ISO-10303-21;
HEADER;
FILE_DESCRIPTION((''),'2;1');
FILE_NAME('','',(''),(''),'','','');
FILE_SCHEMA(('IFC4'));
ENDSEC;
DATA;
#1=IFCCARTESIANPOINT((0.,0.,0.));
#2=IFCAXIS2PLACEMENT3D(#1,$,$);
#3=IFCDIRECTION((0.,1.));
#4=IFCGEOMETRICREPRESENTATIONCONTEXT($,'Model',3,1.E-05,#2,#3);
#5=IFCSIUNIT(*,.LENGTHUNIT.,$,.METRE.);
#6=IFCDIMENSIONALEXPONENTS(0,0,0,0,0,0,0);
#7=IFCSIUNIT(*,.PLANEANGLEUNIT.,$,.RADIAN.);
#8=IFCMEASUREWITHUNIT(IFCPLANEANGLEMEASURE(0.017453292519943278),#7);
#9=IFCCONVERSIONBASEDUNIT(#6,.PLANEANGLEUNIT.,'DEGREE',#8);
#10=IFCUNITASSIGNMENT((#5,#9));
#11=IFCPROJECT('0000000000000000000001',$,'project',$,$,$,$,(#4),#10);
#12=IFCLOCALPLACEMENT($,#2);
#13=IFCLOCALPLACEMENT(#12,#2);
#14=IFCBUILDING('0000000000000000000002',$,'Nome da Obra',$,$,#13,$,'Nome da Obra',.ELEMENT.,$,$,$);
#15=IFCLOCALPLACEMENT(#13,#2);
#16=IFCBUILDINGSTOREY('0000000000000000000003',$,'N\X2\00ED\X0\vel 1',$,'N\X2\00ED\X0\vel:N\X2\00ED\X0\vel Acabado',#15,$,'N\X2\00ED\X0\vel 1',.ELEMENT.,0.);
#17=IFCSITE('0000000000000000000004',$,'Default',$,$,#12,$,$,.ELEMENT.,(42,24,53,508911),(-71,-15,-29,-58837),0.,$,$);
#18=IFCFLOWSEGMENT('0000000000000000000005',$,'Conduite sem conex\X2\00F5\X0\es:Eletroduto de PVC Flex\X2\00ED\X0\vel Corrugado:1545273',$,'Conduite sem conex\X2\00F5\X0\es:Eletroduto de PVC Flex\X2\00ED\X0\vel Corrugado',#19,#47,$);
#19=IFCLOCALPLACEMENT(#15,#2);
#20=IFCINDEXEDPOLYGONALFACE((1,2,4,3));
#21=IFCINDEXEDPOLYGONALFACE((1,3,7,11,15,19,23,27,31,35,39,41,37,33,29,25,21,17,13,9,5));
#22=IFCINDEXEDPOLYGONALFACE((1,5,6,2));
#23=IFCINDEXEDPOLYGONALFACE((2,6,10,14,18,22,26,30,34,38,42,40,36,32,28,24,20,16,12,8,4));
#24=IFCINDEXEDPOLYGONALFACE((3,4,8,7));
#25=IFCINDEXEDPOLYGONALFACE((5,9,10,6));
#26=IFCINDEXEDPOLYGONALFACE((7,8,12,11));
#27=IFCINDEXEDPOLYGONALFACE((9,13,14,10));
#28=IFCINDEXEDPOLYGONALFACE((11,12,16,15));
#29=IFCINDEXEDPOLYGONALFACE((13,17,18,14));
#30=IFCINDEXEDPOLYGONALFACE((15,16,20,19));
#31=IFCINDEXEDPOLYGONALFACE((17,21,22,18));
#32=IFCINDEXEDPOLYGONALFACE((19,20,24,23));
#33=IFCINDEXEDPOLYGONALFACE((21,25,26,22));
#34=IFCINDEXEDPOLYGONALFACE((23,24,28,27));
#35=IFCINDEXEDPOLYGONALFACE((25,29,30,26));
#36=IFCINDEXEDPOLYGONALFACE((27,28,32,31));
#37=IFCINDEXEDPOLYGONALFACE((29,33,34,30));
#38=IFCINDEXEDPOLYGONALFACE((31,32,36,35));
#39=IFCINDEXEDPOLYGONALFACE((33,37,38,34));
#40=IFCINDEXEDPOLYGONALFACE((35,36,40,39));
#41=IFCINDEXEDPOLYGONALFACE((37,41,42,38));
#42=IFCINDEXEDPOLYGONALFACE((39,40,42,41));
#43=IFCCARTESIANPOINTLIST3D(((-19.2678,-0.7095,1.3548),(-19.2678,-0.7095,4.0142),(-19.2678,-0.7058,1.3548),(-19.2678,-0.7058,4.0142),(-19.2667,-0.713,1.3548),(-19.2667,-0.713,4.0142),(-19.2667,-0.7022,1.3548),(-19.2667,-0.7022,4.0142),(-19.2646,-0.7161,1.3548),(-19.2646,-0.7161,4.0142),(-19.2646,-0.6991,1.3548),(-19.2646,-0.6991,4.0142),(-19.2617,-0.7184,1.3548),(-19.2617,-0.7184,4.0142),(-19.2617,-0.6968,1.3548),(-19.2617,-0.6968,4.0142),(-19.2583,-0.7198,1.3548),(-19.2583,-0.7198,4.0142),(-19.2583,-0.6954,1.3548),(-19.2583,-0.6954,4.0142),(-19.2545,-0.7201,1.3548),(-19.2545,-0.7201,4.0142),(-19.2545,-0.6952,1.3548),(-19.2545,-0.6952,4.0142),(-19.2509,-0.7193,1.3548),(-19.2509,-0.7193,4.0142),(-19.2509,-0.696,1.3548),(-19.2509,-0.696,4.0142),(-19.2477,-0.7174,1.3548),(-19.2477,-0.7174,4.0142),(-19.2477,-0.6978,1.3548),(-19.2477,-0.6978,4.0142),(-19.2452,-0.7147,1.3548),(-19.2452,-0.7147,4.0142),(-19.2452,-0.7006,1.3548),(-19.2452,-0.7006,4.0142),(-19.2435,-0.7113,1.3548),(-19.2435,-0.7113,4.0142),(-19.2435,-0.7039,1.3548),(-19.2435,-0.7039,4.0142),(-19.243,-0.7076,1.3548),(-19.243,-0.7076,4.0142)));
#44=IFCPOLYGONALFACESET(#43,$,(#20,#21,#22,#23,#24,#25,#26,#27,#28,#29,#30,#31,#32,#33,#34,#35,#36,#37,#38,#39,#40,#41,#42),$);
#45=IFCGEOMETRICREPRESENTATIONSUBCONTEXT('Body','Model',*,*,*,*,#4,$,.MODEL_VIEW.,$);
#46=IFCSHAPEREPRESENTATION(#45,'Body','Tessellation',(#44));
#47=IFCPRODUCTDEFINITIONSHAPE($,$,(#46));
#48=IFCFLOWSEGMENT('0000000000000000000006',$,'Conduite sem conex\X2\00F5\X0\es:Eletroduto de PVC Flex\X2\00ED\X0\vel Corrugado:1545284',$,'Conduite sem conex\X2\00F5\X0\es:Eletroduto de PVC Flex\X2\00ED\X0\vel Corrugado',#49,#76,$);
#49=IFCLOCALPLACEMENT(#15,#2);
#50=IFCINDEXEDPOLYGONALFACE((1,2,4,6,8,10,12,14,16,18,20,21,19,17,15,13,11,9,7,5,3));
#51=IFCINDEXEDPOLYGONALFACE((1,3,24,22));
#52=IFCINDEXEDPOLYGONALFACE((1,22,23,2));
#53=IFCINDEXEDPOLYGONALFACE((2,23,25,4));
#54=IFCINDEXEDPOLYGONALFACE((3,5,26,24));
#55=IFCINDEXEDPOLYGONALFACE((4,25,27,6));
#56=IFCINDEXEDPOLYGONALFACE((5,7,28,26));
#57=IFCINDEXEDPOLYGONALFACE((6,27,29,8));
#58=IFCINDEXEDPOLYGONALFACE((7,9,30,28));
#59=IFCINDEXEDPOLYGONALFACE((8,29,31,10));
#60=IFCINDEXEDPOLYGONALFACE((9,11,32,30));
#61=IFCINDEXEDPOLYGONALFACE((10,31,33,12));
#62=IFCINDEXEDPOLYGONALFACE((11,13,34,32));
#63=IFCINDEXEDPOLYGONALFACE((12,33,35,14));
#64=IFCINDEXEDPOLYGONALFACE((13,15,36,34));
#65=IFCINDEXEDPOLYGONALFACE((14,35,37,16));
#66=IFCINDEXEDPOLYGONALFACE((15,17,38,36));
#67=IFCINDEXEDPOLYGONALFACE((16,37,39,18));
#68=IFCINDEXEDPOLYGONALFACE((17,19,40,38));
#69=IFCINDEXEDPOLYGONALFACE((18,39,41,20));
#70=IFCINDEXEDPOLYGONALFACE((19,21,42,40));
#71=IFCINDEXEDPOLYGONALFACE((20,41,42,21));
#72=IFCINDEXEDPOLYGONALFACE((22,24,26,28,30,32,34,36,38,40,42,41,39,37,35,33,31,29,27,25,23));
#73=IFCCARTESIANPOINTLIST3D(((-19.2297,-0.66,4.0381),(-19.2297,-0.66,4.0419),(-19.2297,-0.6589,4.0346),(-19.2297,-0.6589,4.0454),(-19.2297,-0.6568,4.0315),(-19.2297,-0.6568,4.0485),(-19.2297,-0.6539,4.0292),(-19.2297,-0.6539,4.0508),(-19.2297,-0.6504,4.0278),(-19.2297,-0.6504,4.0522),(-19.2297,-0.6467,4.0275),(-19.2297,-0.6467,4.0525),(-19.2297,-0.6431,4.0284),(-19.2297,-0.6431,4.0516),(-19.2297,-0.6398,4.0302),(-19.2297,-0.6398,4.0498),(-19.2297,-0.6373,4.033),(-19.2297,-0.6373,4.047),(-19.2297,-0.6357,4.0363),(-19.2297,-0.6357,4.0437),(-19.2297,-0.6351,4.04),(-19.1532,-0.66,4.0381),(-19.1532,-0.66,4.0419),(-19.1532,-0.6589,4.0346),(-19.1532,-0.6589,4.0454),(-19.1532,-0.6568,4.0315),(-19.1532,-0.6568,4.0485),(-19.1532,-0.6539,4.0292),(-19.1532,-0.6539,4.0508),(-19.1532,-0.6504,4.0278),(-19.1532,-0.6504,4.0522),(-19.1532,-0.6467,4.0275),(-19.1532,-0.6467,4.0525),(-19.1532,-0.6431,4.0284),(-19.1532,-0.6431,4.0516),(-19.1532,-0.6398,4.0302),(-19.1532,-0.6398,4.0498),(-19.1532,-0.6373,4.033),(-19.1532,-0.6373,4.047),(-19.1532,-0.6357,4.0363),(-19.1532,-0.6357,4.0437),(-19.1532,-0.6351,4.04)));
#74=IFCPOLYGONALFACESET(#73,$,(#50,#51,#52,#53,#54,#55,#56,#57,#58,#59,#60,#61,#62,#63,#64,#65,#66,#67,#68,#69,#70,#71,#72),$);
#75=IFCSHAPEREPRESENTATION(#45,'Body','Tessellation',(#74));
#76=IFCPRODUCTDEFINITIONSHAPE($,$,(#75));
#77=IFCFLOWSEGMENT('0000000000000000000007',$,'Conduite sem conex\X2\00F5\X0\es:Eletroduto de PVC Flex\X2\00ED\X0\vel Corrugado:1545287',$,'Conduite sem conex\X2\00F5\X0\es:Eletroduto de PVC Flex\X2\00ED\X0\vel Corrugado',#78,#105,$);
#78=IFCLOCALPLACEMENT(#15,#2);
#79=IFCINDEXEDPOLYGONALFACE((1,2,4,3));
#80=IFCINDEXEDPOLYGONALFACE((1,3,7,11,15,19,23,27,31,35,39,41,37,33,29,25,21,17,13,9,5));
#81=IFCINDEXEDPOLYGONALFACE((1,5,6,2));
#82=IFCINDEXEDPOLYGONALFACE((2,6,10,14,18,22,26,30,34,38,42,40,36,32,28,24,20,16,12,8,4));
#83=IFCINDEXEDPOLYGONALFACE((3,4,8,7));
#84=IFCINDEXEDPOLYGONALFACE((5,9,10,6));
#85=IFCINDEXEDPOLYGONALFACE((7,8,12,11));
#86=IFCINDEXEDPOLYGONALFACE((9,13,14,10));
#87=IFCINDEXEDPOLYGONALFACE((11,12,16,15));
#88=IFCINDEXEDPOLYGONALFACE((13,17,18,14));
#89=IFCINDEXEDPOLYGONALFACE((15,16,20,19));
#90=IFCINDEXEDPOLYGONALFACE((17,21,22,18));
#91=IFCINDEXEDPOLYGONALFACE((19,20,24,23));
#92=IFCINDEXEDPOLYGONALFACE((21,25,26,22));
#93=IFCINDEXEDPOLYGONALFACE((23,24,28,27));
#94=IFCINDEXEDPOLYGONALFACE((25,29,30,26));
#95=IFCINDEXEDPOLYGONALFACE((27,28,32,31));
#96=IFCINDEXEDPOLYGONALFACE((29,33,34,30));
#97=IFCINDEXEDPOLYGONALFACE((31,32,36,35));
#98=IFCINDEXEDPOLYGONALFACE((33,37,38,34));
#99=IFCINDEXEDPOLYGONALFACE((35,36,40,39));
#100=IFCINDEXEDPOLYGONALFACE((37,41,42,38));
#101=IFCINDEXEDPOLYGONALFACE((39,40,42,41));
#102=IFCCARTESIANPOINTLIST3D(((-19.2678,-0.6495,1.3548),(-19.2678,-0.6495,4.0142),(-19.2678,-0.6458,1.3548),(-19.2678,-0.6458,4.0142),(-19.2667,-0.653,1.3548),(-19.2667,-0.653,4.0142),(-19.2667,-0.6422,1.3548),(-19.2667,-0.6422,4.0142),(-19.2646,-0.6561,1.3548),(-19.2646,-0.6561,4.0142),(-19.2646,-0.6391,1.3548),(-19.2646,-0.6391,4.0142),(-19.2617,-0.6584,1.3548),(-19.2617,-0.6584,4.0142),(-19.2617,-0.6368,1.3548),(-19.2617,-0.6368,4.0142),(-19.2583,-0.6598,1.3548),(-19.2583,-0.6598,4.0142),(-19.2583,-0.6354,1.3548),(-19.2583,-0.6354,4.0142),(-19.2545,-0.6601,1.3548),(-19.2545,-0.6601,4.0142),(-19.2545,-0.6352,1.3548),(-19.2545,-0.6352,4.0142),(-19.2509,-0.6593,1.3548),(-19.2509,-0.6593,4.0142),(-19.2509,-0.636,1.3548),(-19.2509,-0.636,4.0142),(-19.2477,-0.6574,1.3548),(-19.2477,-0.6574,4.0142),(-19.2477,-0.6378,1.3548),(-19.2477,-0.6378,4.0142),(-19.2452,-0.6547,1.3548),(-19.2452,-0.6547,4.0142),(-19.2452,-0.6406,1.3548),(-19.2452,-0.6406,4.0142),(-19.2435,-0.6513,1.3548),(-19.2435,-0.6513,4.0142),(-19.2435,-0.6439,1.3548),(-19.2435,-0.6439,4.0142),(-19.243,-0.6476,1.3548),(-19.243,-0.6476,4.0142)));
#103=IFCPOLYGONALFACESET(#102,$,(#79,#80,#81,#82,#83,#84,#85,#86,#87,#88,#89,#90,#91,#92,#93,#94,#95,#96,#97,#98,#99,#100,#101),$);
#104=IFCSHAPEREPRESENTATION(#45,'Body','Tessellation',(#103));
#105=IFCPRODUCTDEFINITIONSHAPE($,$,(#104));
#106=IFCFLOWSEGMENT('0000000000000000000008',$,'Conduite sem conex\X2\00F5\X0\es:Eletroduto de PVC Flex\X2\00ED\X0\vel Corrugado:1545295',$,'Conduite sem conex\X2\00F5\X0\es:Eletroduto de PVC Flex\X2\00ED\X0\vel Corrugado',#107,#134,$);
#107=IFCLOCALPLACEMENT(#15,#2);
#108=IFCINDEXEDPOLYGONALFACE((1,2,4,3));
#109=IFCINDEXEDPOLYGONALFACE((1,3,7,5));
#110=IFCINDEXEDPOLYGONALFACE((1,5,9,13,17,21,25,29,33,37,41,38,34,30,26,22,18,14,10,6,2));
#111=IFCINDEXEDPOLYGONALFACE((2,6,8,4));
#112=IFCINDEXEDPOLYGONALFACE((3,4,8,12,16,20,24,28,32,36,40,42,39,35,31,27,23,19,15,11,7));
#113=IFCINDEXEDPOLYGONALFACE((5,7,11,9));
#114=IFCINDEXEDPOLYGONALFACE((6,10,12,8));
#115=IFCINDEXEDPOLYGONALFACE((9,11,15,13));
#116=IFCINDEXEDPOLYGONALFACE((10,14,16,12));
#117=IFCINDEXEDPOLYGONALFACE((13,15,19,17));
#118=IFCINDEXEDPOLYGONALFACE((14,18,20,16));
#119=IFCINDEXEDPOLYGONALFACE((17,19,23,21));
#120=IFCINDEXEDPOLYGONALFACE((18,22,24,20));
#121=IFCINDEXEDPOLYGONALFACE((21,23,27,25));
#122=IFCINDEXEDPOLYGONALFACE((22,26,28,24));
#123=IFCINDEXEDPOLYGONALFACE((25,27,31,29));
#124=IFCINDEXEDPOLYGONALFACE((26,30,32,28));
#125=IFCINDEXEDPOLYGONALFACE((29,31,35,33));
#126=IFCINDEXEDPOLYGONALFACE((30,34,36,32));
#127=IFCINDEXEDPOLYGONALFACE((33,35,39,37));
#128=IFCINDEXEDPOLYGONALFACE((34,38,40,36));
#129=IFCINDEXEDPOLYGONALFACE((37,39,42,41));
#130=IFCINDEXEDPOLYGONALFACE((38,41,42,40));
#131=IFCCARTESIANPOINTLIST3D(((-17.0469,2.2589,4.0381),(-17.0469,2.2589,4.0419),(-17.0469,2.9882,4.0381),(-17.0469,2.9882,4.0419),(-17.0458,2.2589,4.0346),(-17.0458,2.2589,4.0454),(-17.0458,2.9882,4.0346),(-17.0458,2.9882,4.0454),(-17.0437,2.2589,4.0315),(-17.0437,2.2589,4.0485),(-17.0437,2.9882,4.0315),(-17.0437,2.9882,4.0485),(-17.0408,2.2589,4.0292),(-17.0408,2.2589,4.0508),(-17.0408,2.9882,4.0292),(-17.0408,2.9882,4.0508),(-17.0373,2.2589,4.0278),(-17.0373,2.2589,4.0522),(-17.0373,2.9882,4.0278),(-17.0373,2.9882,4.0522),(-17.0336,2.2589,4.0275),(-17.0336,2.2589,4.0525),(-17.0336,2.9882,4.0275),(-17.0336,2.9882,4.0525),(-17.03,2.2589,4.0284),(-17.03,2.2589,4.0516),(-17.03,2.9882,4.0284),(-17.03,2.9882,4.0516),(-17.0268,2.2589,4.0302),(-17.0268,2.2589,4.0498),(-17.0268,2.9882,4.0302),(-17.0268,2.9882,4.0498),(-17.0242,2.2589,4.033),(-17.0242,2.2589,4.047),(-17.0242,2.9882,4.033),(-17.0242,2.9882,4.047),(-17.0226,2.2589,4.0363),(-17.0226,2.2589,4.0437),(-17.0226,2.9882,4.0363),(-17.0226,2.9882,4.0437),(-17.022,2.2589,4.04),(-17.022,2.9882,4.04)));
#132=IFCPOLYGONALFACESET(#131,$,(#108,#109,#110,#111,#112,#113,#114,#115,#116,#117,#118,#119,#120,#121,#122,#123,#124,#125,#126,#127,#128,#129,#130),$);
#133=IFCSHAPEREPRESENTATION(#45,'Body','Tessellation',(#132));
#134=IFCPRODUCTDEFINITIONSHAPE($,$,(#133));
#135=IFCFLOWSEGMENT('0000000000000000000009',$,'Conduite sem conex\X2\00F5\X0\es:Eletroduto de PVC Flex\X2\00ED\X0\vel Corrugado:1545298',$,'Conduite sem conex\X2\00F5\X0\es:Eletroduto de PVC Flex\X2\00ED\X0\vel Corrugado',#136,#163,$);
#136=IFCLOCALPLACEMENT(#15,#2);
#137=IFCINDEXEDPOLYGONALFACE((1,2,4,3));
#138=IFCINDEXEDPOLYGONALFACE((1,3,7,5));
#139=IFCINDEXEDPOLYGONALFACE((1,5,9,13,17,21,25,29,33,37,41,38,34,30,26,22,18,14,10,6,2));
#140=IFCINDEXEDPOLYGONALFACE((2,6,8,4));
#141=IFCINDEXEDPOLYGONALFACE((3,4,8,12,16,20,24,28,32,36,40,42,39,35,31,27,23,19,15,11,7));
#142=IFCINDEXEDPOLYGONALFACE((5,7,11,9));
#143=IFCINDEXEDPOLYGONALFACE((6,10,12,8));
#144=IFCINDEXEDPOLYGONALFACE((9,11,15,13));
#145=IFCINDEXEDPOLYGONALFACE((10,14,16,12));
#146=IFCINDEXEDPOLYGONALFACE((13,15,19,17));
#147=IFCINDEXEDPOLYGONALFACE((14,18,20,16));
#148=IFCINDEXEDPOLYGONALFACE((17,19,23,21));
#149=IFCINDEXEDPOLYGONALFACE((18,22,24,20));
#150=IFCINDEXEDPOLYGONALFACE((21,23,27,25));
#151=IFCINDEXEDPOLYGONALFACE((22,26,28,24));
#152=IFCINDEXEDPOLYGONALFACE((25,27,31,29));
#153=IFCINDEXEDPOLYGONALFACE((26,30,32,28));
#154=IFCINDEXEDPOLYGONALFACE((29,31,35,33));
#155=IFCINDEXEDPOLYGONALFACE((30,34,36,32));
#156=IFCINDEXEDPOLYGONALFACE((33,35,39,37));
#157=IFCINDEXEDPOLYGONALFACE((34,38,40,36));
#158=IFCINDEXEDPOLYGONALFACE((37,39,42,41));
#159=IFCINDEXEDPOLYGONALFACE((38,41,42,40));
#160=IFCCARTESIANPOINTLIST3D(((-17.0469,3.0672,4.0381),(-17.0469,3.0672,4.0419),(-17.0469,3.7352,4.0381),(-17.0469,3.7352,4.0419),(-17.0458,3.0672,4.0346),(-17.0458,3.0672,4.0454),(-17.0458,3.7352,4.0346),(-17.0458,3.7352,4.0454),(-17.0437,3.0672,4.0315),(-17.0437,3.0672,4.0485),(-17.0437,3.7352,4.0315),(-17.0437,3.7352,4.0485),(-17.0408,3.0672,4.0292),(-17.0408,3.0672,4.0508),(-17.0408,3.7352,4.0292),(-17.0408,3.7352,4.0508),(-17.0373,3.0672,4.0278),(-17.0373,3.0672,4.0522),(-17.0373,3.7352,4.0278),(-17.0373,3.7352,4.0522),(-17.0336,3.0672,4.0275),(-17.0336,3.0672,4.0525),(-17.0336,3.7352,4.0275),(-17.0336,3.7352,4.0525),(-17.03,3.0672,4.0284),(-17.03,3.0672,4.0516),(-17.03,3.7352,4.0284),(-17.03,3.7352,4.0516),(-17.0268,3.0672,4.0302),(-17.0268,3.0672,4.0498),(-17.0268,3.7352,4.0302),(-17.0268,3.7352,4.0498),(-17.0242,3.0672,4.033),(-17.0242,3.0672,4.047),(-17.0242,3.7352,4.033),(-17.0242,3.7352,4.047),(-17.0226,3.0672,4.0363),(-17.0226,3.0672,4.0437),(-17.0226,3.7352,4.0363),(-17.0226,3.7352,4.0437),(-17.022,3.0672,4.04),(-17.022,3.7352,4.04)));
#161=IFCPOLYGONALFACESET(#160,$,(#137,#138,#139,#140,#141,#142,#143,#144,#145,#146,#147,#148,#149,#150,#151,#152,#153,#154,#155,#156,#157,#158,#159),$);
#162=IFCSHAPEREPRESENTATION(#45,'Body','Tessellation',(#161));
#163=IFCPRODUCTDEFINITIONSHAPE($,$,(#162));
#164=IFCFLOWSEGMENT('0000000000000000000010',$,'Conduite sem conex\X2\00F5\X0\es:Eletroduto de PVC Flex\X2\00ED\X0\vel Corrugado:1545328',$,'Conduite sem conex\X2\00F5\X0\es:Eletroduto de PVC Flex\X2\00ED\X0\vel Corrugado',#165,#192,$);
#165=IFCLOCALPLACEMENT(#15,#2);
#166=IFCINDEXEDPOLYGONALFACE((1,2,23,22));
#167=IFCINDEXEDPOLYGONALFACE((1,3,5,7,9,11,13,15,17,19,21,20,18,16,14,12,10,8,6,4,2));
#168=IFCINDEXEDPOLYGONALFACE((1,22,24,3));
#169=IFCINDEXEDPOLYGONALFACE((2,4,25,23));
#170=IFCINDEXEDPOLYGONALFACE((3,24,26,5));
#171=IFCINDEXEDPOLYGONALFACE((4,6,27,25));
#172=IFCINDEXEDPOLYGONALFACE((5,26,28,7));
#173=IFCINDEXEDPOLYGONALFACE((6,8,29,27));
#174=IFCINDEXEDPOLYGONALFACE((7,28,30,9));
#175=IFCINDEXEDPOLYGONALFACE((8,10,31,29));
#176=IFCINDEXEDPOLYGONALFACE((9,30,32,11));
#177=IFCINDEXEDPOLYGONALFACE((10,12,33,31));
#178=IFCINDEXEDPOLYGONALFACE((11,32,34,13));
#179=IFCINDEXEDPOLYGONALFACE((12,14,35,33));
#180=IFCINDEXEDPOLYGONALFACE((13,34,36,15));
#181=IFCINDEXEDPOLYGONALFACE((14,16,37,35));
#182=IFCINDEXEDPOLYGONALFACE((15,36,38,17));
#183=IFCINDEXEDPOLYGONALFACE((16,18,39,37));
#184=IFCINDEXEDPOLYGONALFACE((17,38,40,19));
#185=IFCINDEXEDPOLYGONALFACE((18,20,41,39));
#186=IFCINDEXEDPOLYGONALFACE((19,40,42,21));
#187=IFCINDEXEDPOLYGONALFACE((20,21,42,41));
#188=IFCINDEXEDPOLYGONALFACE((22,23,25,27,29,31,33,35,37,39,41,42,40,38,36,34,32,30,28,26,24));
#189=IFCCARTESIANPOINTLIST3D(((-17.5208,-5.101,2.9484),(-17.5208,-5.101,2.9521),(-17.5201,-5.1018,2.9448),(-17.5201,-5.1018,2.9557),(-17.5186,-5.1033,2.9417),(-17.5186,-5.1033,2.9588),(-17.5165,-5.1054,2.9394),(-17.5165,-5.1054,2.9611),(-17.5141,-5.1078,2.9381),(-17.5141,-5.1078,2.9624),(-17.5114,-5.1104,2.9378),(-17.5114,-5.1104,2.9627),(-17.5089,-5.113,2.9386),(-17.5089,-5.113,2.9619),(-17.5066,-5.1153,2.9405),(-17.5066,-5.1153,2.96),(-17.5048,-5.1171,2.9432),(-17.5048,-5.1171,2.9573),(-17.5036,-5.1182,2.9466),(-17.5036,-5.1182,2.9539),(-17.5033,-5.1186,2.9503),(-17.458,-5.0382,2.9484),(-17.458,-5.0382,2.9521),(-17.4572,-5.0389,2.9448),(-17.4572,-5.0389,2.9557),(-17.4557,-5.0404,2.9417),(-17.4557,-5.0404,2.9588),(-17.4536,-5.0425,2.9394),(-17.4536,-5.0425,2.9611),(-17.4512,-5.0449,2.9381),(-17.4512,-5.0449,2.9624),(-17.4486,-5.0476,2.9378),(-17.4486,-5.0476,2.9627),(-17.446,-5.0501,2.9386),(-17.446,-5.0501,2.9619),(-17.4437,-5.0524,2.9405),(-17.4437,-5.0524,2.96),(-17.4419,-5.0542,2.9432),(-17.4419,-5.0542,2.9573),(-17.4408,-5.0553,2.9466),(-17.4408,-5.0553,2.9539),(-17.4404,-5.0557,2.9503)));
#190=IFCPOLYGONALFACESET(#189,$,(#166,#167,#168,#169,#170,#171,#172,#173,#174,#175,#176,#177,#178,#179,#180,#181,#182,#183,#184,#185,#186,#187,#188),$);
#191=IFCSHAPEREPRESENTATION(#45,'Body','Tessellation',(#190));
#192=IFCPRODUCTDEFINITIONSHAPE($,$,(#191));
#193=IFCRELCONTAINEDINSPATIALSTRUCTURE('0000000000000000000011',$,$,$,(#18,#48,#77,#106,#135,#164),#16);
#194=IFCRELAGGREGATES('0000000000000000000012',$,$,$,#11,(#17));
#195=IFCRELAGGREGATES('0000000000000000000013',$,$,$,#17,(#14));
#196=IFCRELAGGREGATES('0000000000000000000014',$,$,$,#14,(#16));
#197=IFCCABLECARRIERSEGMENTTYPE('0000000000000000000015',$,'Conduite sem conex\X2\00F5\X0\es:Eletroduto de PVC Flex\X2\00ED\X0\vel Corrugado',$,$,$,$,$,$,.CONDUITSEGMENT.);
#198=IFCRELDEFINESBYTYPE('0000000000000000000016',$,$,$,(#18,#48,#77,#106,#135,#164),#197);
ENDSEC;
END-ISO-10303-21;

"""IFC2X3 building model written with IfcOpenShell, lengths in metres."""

from ifc_helpers import new_model, entity, si_unit, converted_unit, direction, frame, frame_2d, origin, origin_2d_with_axis, place, context, subcontext, project, spatial, circle, extrude, type_object, element, save


model = new_model("IFC2X3")

# Units and contexts
model_context = context("Model", 3, precision=1e-05, world=origin(), true_north=direction((0.0, 1.0)))
body_context = subcontext(model_context, "Body", "Model", "MODEL_VIEW")
ifc_project = project(units=[si_unit("LENGTHUNIT", "METRE"), converted_unit("PLANEANGLEUNIT", "DEGREE", entity("IfcPlaneAngleMeasure", 0.017453292519943278), si_unit("PLANEANGLEUNIT", "RADIAN"), dimensions=[0, 0, 0, 0, 0, 0, 0])], contexts=[model_context])

# Site, building, storey
site_placement = place(None, origin())
site = spatial("IfcSite", under=ifc_project, at=site_placement, Name="Default", CompositionType="ELEMENT", RefLatitude=(42, 24, 53, 508911), RefLongitude=(-71, -15, -29, -58837), RefElevation=0.0)
building_placement = place(site_placement, origin())
building = spatial("IfcBuilding", under=site, at=building_placement, Name="Nome da Obra", LongName="Nome da Obra", CompositionType="ELEMENT")
storey_placement = place(building_placement, origin())
storey = spatial("IfcBuildingStorey", under=building, at=storey_placement, Name="Nível 1", ObjectType="Nível:Nível Acabado", LongName="Nível 1", CompositionType="ELEMENT", Elevation=0.0)

# Flow segments
cable_carrier_segment_type = type_object("IfcCableCarrierSegmentType", Name="Conduite sem conexões:Eletroduto de PVC Flexível Corrugado", PredefinedType="CONDUITSEGMENT")
flow_segment_1_placement = place(storey_placement, origin())
element("IfcFlowSegment", 1, at=flow_segment_1_placement, inside=storey, type_object=cable_carrier_segment_type, Name="Conduite sem conexões:Eletroduto de PVC Flexível Corrugado:1545273", ObjectType="Conduite sem conexões:Eletroduto de PVC Flexível Corrugado", context=body_context, shape_type="SweptSolid", body=[
    extrude(circle(Radius=0.0125, at=origin_2d_with_axis()), frame((-19.2555, -0.7076, 1.3548)), (0.0, 0.0, 1.0), 2.6594),
])
flow_segment_2_placement = place(storey_placement, origin())
element("IfcFlowSegment", 2, at=flow_segment_2_placement, inside=storey, type_object=cable_carrier_segment_type, Name="Conduite sem conexões:Eletroduto de PVC Flexível Corrugado:1545284", ObjectType="Conduite sem conexões:Eletroduto de PVC Flexível Corrugado", context=body_context, shape_type="SweptSolid", body=[
    extrude(circle(Radius=0.0125, at=frame_2d((0.0, 0.0), x_axis=(1.0, 0.0))), frame((-19.2297, -0.6476, 4.04), z_axis=(1.0, 0.0, 0.0), x_axis=(0.0, 1.0, 0.0)), (0.0, 0.0, 1.0), 0.0765),
])
flow_segment_3_placement = place(storey_placement, origin())
element("IfcFlowSegment", 3, at=flow_segment_3_placement, inside=storey, type_object=cable_carrier_segment_type, Name="Conduite sem conexões:Eletroduto de PVC Flexível Corrugado:1545287", ObjectType="Conduite sem conexões:Eletroduto de PVC Flexível Corrugado", context=body_context, shape_type="SweptSolid", body=[
    extrude(circle(Radius=0.0125, at=origin_2d_with_axis()), frame((-19.2555, -0.6476, 1.3548)), (0.0, 0.0, 1.0), 2.6594),
])
flow_segment_4_placement = place(storey_placement, origin())
element("IfcFlowSegment", 4, at=flow_segment_4_placement, inside=storey, type_object=cable_carrier_segment_type, Name="Conduite sem conexões:Eletroduto de PVC Flexível Corrugado:1545295", ObjectType="Conduite sem conexões:Eletroduto de PVC Flexível Corrugado", context=body_context, shape_type="SweptSolid", body=[
    extrude(circle(Radius=0.0125, at=frame_2d((0.0, 0.0), x_axis=(1.0, 0.0))), frame((-17.0345, 2.2589, 4.04), z_axis=(0.0, 1.0, 0.0), x_axis=(1.0, 0.0, 0.0)), (0.0, 0.0, 1.0), 0.7293),
])
flow_segment_5_placement = place(storey_placement, origin())
element("IfcFlowSegment", 5, at=flow_segment_5_placement, inside=storey, type_object=cable_carrier_segment_type, Name="Conduite sem conexões:Eletroduto de PVC Flexível Corrugado:1545298", ObjectType="Conduite sem conexões:Eletroduto de PVC Flexível Corrugado", context=body_context, shape_type="SweptSolid", body=[
    extrude(circle(Radius=0.0125, at=frame_2d((0.0, 0.0), x_axis=(1.0, 0.0))), frame((-17.0345, 3.0672, 4.04), z_axis=(0.0, 1.0, 0.0), x_axis=(1.0, 0.0, 0.0)), (0.0, 0.0, 1.0), 0.668),
])
flow_segment_6_placement = place(storey_placement, origin())
element("IfcFlowSegment", 6, at=flow_segment_6_placement, inside=storey, type_object=cable_carrier_segment_type, Name="Conduite sem conexões:Eletroduto de PVC Flexível Corrugado:1545328", ObjectType="Conduite sem conexões:Eletroduto de PVC Flexível Corrugado", context=body_context, shape_type="SweptSolid", body=[
    extrude(circle(Radius=0.0125, at=frame_2d((0.0, 0.0), x_axis=(1.0, 0.0))), frame((-17.5121, -5.1098, 2.9503), z_axis=(0.707107, 0.707107, 0.0), x_axis=(0.707107, -0.707107, 0.0)), (0.0, 0.0, 1.0), 0.0889),
])

save(model, "model.ifc")
